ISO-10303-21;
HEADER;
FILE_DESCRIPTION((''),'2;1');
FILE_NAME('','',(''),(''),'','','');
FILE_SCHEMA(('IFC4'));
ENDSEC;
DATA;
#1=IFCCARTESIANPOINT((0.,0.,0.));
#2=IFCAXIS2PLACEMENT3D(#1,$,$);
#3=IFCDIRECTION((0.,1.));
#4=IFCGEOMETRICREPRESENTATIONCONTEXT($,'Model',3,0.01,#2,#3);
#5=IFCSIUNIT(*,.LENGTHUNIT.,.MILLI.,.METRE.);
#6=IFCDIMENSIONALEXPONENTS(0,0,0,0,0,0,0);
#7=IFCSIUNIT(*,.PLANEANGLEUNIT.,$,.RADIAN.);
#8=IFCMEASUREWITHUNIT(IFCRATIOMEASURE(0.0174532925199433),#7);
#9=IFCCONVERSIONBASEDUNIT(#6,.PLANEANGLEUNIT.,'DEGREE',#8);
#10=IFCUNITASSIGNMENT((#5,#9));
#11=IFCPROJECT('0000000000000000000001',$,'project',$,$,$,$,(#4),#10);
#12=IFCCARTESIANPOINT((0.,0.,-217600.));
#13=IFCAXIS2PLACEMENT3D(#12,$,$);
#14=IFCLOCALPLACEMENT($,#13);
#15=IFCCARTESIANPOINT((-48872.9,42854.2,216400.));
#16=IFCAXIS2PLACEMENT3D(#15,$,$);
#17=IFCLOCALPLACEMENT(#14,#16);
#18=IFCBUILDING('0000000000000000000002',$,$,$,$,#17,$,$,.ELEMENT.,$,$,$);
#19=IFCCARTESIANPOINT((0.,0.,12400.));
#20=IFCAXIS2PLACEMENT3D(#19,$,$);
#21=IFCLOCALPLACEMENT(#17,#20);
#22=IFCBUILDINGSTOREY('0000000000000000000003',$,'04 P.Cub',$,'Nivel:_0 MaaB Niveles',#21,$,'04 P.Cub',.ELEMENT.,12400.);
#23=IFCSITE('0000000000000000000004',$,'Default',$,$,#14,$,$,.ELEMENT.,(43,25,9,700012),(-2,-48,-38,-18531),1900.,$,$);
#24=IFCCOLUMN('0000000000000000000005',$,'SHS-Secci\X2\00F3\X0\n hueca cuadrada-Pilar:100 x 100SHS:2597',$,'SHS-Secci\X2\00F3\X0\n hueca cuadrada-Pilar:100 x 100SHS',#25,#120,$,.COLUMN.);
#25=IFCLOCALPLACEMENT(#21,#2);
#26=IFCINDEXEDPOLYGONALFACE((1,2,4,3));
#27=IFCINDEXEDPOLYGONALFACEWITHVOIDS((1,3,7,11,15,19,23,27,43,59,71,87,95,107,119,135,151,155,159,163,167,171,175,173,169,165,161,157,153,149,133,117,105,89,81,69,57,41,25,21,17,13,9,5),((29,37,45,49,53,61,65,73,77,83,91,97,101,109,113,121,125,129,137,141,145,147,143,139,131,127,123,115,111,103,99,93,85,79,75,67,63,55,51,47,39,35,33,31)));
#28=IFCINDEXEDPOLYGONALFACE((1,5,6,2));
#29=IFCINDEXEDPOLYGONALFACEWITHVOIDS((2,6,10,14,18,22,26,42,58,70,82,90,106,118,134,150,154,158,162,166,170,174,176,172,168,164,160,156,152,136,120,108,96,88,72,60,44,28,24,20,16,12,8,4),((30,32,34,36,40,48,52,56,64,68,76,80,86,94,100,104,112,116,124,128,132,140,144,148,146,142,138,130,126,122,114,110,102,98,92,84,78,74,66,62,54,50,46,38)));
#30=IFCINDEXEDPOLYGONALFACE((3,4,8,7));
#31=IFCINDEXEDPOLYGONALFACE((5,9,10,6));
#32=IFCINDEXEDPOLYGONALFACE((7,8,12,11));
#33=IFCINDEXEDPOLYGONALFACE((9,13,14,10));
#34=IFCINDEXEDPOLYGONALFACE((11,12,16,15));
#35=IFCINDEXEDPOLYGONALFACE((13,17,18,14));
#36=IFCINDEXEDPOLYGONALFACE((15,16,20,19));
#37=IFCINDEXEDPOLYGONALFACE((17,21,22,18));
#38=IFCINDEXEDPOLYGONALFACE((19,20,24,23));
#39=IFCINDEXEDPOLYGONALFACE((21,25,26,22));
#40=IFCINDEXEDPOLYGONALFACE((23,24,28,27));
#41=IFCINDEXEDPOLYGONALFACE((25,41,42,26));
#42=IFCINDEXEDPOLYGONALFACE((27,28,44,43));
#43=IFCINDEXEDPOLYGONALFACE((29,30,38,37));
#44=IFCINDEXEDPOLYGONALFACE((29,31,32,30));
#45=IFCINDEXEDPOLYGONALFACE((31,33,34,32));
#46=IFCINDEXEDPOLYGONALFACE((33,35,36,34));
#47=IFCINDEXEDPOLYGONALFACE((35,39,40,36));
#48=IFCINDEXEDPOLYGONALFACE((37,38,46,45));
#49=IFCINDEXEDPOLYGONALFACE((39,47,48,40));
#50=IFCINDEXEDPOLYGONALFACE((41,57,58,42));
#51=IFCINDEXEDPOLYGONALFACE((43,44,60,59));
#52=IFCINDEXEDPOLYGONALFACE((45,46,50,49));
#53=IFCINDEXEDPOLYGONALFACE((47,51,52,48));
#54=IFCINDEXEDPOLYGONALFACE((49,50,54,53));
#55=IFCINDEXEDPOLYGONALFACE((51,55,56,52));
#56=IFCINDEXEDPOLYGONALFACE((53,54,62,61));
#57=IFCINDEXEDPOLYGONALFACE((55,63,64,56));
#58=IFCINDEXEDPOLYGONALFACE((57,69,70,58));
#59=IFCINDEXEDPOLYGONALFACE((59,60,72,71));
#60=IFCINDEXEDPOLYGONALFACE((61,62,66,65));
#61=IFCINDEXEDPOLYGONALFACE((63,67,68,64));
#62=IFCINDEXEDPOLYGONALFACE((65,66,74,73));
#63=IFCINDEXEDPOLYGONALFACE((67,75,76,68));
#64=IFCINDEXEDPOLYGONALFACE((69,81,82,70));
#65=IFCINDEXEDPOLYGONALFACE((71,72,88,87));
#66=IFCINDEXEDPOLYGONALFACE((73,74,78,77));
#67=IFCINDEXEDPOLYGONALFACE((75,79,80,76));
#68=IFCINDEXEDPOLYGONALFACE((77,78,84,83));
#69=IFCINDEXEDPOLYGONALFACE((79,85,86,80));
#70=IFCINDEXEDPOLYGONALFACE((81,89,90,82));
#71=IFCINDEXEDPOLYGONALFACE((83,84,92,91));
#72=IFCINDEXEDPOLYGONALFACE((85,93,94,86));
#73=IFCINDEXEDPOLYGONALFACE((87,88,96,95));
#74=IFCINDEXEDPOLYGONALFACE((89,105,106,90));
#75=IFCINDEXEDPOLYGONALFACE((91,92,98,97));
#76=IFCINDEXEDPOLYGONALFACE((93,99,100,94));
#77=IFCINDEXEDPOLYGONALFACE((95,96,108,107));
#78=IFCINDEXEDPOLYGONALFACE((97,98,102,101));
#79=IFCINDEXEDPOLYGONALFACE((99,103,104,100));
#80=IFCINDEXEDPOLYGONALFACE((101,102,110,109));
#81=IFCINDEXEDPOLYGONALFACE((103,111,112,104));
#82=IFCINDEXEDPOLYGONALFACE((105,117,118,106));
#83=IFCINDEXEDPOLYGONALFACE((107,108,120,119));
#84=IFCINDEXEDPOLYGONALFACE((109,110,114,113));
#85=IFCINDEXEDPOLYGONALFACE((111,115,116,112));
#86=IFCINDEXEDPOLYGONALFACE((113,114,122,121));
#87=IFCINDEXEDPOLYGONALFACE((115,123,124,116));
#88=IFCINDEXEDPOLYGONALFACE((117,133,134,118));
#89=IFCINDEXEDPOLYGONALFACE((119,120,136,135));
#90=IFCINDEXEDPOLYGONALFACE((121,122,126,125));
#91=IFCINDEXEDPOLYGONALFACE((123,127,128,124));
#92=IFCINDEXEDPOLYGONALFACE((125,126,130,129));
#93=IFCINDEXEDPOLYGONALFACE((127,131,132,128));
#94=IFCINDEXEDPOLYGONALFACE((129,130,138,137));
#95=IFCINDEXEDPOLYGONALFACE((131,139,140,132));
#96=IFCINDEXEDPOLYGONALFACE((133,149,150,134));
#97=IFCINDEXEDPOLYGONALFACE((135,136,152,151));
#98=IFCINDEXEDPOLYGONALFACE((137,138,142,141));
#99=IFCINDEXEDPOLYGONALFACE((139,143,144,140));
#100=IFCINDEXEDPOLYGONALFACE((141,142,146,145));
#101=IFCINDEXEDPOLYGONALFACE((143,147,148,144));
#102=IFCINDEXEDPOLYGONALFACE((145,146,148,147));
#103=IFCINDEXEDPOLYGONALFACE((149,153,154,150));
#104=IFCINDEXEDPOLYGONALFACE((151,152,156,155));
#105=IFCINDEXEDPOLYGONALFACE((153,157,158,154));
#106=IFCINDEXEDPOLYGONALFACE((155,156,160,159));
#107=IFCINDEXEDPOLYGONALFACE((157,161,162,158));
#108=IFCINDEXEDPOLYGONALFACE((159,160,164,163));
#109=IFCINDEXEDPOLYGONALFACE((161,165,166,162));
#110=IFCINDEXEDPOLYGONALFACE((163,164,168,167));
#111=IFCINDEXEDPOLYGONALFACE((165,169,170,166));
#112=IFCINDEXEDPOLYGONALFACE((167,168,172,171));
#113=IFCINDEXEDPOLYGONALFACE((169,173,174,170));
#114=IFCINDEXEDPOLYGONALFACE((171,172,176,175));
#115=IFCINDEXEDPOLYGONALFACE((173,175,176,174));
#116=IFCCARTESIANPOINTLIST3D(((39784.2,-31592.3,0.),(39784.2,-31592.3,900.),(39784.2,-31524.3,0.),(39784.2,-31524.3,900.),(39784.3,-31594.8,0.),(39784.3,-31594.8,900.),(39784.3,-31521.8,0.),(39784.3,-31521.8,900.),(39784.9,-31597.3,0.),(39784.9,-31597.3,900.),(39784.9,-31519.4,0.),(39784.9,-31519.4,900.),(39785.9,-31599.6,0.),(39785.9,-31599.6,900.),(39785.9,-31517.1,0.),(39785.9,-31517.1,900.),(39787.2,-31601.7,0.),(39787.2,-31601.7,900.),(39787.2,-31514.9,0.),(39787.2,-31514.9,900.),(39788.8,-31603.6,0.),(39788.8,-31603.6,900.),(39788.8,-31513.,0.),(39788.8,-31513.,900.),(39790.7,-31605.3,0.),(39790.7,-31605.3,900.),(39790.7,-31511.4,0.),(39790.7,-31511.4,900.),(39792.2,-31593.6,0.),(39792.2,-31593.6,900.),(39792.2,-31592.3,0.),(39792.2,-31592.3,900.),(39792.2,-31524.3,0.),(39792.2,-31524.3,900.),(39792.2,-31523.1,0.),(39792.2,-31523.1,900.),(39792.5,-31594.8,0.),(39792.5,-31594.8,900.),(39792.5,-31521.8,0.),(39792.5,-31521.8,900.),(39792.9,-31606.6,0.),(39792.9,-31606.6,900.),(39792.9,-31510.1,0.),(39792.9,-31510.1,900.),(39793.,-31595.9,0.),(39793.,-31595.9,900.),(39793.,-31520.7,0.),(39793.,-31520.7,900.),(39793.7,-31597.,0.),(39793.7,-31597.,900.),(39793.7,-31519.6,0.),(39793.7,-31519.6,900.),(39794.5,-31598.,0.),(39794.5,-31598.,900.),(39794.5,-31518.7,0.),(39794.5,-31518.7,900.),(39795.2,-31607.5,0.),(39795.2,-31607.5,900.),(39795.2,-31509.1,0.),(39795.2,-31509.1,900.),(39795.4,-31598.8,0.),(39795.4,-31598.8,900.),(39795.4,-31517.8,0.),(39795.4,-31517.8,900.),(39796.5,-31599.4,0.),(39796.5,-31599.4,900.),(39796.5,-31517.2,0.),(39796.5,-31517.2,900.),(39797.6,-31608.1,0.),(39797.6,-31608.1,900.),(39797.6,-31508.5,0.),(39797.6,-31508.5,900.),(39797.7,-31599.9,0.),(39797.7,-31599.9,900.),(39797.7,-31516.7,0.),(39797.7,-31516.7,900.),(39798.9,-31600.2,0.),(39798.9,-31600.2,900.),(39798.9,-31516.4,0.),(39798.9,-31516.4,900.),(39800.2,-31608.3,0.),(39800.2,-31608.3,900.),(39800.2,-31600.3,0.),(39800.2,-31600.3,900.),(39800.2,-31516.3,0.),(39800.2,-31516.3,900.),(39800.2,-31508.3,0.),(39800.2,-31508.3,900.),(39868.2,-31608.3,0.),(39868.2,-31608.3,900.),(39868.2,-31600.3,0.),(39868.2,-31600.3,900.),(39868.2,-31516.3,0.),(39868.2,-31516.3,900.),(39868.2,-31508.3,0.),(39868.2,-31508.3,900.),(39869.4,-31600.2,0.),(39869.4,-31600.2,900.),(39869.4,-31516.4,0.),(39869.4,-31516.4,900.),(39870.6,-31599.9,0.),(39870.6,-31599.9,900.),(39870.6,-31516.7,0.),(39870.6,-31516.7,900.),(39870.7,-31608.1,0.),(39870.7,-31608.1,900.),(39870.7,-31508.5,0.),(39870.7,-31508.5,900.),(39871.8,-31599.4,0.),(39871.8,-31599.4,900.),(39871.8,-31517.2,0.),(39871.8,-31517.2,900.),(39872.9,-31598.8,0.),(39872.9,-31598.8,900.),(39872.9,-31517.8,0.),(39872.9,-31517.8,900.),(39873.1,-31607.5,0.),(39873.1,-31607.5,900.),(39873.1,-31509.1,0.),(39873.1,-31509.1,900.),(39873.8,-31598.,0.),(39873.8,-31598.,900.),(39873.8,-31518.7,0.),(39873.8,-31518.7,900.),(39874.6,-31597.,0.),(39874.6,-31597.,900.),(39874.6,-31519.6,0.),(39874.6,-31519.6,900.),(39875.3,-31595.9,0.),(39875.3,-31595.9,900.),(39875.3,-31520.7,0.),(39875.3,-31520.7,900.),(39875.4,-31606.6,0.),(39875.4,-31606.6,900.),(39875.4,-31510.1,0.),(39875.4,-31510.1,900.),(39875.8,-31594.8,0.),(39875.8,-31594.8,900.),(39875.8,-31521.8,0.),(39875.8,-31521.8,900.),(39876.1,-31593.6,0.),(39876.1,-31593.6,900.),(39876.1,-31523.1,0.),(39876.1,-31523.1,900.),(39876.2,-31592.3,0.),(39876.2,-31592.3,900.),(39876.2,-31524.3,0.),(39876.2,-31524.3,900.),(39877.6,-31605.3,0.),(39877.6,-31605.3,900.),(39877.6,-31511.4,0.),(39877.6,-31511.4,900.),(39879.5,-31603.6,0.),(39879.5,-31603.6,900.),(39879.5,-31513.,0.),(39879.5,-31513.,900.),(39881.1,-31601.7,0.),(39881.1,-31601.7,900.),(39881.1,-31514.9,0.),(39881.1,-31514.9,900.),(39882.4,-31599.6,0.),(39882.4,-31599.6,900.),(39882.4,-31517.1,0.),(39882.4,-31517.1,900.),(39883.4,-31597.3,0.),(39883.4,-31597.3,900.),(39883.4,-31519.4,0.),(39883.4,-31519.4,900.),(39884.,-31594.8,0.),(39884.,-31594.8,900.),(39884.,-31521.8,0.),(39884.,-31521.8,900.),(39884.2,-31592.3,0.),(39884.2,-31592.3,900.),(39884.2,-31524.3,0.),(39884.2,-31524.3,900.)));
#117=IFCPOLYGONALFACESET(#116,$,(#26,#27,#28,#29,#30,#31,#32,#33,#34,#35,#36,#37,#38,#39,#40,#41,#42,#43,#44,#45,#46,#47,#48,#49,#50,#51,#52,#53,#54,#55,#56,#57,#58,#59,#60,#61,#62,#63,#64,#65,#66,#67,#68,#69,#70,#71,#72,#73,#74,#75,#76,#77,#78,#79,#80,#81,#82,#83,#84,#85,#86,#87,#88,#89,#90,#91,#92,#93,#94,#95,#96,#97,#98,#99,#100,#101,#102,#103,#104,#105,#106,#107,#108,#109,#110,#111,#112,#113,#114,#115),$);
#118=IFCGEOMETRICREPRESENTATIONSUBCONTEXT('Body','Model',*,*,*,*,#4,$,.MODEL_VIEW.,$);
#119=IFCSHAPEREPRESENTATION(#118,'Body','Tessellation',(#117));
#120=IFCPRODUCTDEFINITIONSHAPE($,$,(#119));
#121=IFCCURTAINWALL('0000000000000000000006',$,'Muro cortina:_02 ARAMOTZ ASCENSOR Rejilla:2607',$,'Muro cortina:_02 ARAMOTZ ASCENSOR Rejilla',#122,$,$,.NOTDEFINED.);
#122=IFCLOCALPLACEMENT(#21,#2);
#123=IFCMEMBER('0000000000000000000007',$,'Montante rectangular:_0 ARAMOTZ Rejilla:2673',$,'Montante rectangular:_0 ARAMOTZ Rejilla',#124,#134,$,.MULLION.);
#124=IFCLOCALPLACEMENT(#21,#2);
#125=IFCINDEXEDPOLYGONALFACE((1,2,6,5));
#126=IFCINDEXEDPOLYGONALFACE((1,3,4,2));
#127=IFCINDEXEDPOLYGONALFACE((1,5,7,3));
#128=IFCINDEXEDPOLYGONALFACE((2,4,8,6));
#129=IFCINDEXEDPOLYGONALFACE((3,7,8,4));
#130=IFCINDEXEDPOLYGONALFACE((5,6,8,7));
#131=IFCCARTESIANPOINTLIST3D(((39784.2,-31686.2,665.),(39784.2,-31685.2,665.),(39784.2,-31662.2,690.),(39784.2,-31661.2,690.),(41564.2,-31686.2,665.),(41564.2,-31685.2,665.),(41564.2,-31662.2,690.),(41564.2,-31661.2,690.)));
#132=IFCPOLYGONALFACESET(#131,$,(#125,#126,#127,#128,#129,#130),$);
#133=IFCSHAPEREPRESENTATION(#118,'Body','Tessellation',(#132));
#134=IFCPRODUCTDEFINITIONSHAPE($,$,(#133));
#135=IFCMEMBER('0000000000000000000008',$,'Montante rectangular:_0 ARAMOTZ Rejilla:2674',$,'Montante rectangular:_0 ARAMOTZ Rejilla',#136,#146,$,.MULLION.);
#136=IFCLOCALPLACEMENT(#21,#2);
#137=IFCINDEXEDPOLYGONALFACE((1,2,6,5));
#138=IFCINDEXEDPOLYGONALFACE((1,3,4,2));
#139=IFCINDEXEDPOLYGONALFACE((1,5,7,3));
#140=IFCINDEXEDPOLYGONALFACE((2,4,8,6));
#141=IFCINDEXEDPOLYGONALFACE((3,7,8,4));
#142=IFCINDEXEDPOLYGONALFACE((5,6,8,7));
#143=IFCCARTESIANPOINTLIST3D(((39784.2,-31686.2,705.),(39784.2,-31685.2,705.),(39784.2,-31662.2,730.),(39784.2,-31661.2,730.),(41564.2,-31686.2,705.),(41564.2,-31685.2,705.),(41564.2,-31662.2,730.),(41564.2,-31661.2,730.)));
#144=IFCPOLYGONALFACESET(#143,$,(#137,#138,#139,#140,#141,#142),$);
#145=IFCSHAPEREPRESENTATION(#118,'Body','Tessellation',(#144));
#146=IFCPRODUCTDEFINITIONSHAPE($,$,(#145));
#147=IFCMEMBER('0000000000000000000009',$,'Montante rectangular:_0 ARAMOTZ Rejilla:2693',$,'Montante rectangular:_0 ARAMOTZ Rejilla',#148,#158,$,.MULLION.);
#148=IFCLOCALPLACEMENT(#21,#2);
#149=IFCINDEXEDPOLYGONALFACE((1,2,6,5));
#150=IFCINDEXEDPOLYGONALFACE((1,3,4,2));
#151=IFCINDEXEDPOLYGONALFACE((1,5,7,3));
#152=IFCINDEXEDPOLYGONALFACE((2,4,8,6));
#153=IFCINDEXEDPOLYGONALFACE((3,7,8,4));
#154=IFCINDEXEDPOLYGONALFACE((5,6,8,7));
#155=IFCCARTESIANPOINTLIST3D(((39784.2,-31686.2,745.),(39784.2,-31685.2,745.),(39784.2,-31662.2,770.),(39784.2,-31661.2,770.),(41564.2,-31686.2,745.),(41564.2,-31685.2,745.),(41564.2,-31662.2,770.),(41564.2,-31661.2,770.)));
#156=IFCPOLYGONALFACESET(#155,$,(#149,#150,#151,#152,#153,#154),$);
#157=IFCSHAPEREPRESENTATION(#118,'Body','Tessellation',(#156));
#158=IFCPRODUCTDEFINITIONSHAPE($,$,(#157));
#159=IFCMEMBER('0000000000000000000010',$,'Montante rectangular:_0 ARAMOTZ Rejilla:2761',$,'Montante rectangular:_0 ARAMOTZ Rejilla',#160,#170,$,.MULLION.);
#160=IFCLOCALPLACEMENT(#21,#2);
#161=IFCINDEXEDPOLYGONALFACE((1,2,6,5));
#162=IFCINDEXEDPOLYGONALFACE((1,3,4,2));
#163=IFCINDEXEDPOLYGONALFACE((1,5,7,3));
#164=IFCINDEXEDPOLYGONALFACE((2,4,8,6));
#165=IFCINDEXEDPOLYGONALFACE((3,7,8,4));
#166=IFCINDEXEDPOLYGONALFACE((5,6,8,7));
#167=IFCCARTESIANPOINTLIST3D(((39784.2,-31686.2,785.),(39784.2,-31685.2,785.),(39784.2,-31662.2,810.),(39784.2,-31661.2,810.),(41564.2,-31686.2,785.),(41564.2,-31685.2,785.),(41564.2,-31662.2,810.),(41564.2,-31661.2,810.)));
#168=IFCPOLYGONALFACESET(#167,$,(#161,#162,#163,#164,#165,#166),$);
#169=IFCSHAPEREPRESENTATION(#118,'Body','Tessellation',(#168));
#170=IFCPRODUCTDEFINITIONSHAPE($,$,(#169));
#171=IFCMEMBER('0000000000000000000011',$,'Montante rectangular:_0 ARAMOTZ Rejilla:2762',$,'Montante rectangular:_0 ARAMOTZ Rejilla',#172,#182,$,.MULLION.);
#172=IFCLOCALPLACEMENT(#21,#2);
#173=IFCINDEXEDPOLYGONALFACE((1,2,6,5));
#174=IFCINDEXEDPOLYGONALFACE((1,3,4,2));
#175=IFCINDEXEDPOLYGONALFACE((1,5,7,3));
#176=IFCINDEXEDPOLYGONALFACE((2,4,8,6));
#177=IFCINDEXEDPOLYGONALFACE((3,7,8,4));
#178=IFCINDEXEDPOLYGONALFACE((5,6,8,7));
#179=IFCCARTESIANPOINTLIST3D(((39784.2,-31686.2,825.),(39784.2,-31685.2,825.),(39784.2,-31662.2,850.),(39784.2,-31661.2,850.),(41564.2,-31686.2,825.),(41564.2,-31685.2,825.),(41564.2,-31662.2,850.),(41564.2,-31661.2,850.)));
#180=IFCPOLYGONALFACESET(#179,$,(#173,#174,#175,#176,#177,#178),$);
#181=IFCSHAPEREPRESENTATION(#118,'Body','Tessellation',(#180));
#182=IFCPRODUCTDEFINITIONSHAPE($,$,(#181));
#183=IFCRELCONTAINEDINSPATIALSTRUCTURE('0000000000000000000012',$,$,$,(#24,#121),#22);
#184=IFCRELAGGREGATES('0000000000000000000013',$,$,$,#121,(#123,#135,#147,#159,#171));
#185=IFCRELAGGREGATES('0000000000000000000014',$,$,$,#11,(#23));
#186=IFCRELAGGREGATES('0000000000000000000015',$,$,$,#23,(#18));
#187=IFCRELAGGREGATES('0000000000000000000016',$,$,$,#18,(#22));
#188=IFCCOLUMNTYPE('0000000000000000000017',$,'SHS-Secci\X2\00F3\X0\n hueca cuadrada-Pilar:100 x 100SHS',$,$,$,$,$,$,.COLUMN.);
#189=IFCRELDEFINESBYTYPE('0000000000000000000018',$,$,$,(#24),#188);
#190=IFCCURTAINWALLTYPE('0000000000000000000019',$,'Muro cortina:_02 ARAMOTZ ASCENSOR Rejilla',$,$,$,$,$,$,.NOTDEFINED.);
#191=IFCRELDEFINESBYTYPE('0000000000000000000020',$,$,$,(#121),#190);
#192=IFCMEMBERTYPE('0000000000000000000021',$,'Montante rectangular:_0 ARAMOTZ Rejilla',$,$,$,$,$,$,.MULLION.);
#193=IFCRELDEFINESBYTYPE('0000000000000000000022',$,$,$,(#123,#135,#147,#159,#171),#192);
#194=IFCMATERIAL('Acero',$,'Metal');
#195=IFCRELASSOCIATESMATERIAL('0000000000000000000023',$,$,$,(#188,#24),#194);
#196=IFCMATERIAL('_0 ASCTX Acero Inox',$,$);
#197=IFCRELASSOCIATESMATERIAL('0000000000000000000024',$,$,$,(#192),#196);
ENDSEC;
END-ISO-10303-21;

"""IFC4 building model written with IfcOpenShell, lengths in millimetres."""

from ifc_helpers import new_model, entity, si_unit, converted_unit, direction, frame, origin, place, context, subcontext, project, spatial, indexed_curve, outline, extrude, source, transform, mapped, material, type_object, type_shapes, element, aggregate, save


model = new_model("IFC4")

# Units and contexts
model_context = context("Model", 3, precision=0.01, world=origin(), true_north=direction((0.0, 1.0)))
body_context = subcontext(model_context, "Body", "Model", "MODEL_VIEW")
ifc_project = project(units=[si_unit("LENGTHUNIT", "METRE", prefix="MILLI"), converted_unit("PLANEANGLEUNIT", "DEGREE", entity("IfcRatioMeasure", 0.0174532925199433), si_unit("PLANEANGLEUNIT", "RADIAN"), dimensions=[0, 0, 0, 0, 0, 0, 0])], contexts=[model_context])

# Site, building, storey
site_placement = place(None, frame((0.0, 0.0, -217600.0)))
site = spatial("IfcSite", under=ifc_project, at=site_placement, Name="Default", CompositionType="ELEMENT", RefLatitude=(43, 25, 9, 700012), RefLongitude=(-2, -48, -38, -18531), RefElevation=1900.0)
building_placement = place(site_placement, frame((-48872.9, 42854.2, 216400.0)))
building = spatial("IfcBuilding", under=site, at=building_placement, CompositionType="ELEMENT")
storey_placement = place(building_placement, frame((0.0, 0.0, 12400.0)))
storey = spatial("IfcBuildingStorey", under=building, at=storey_placement, Name="04 P.Cub", ObjectType="Nivel:_0 MaaB Niveles", LongName="04 P.Cub", CompositionType="ELEMENT", Elevation=12400.0)

# Column
ifc_material_1 = material(Name="Acero", Category="Metal")
column_type_1 = type_object("IfcColumnType", Name="SHS-Sección hueca cuadrada-Pilar:100 x 100SHS", PredefinedType="COLUMN", material=ifc_material_1)
shared_shape_1 = source(origin(), body_context, "Body", "SweptSolid", [
    extrude(outline(indexed_curve([(-34.0, -50.0), (34.0, -50.0), (36.5, -49.8), (38.9, -49.2), (41.3, -48.3), (43.4, -46.9), (45.3, -45.3), (46.9, -43.4), (48.3, -41.3), (49.2, -38.9), (49.8, -36.5), (50.0, -34.0), (50.0, 34.0), (49.8, 36.5), (49.2, 38.9), (48.3, 41.3), (46.9, 43.4), (45.3, 45.3), (43.4, 46.9), (41.3, 48.3), (38.9, 49.2), (36.5, 49.8), (34.0, 50.0), (-34.0, 50.0), (-36.5, 49.8), (-38.9, 49.2), (-41.3, 48.3), (-43.4, 46.9), (-45.3, 45.3), (-46.9, 43.4), (-48.3, 41.3), (-49.2, 38.9), (-49.8, 36.5), (-50.0, 34.0), (-50.0, -34.0), (-49.8, -36.5), (-49.2, -38.9), (-48.3, -41.3), (-46.9, -43.4), (-45.3, -45.3), (-43.4, -46.9), (-41.3, -48.3), (-38.9, -49.2), (-36.5, -49.8), (-34.0, -50.0)], self_intersect=False), holes=[indexed_curve([(-34.0, -42.0), (-35.3, -41.9), (-36.5, -41.6), (-37.6, -41.1), (-38.7, -40.5), (-39.7, -39.7), (-40.5, -38.7), (-41.1, -37.6), (-41.6, -36.5), (-41.9, -35.3), (-42.0, -34.0), (-42.0, 34.0), (-41.9, 35.3), (-41.6, 36.5), (-41.1, 37.6), (-40.5, 38.7), (-39.7, 39.7), (-38.7, 40.5), (-37.6, 41.1), (-36.5, 41.6), (-35.3, 41.9), (-34.0, 42.0), (34.0, 42.0), (35.3, 41.9), (36.5, 41.6), (37.6, 41.1), (38.7, 40.5), (39.7, 39.7), (40.5, 38.7), (41.1, 37.6), (41.6, 36.5), (41.9, 35.3), (42.0, 34.0), (42.0, -34.0), (41.9, -35.3), (41.6, -36.5), (41.1, -37.6), (40.5, -38.7), (39.7, -39.7), (38.7, -40.5), (37.6, -41.1), (36.5, -41.6), (35.3, -41.9), (34.0, -42.0), (-34.0, -42.0)], self_intersect=False)]), frame((0.0, 0.0, 12400.0), z_axis=(0.0, 0.0, 1.0), x_axis=(-1.0, 0.0, 0.0)), (0.0, 0.0, 1.0), 900.0),
])
type_shapes(column_type_1, [shared_shape_1])
column_1_placement = place(storey_placement, frame((39834.2, -31558.3, -12400.0), z_axis=(0.0, 0.0, 1.0), x_axis=(0.0, -1.0, 0.0)))
element("IfcColumn", 1, at=column_1_placement, inside=storey, type_object=column_type_1, material=ifc_material_1, Name="SHS-Sección hueca cuadrada-Pilar:100 x 100SHS:2597", ObjectType="SHS-Sección hueca cuadrada-Pilar:100 x 100SHS", PredefinedType="COLUMN", context=body_context, shape_type="MappedRepresentation", body=[
    mapped(shared_shape_1, transform((0.0, 0.0, 0.0), scale=1.0)),
])

# Curtain wall, members
curtain_wall_type = type_object("IfcCurtainWallType", Name="Muro cortina:_02 ARAMOTZ ASCENSOR Rejilla", PredefinedType="NOTDEFINED")
curtain_wall_placement = place(storey_placement, frame((0.0, 0.0, -12400.0)))
curtain_wall = element("IfcCurtainWall", 2, at=curtain_wall_placement, inside=storey, type_object=curtain_wall_type, Name="Muro cortina:_02 ARAMOTZ ASCENSOR Rejilla:2607", ObjectType="Muro cortina:_02 ARAMOTZ ASCENSOR Rejilla", PredefinedType="NOTDEFINED")
ifc_material_2 = material(Name="_0 ASCTX Acero Inox")
member_type = type_object("IfcMemberType", Name="Montante rectangular:_0 ARAMOTZ Rejilla", PredefinedType="MULLION", material=ifc_material_2)
shared_shape_2 = source(origin(), body_context, "Body", "SweptSolid", [
    extrude(outline(indexed_curve([(11.5, -12.5), (12.5, -12.5), (-11.5, 12.5), (-12.5, 12.5), (11.5, -12.5)], self_intersect=False)), frame((-12.5, -22.5, -1780.0), z_axis=(0.0, 0.0, 1.0), x_axis=(0.0, -1.0, 0.0)), (0.0, 0.0, 1.0), 1780.0),
])
type_shapes(member_type, [shared_shape_2])
member_1_placement = place(curtain_wall_placement, frame((39784.2, -31651.2, 13090.0), z_axis=(-1.0, 0.0, 0.0), x_axis=(0.0, 0.0, 1.0)))
member_1 = element("IfcMember", 3, at=member_1_placement, type_object=member_type, Name="Montante rectangular:_0 ARAMOTZ Rejilla:2673", ObjectType="Montante rectangular:_0 ARAMOTZ Rejilla", PredefinedType="MULLION", context=body_context, shape_type="MappedRepresentation", body=[
    mapped(shared_shape_2, transform((0.0, 0.0, 0.0), scale=1.0)),
])
member_2_placement = place(curtain_wall_placement, frame((39784.2, -31651.2, 13130.0), z_axis=(-1.0, 0.0, 0.0), x_axis=(0.0, 0.0, 1.0)))
member_2 = element("IfcMember", 4, at=member_2_placement, type_object=member_type, Name="Montante rectangular:_0 ARAMOTZ Rejilla:2674", ObjectType="Montante rectangular:_0 ARAMOTZ Rejilla", PredefinedType="MULLION", context=body_context, shape_type="MappedRepresentation", body=[
    mapped(shared_shape_2, transform((0.0, 0.0, 0.0), scale=1.0)),
])
member_3_placement = place(curtain_wall_placement, frame((39784.2, -31651.2, 13170.0), z_axis=(-1.0, 0.0, 0.0), x_axis=(0.0, 0.0, 1.0)))
member_3 = element("IfcMember", 5, at=member_3_placement, type_object=member_type, Name="Montante rectangular:_0 ARAMOTZ Rejilla:2693", ObjectType="Montante rectangular:_0 ARAMOTZ Rejilla", PredefinedType="MULLION", context=body_context, shape_type="MappedRepresentation", body=[
    mapped(shared_shape_2, transform((0.0, 0.0, 0.0), scale=1.0)),
])
member_4_placement = place(curtain_wall_placement, frame((39784.2, -31651.2, 13210.0), z_axis=(-1.0, 0.0, 0.0), x_axis=(0.0, 0.0, 1.0)))
member_4 = element("IfcMember", 6, at=member_4_placement, type_object=member_type, Name="Montante rectangular:_0 ARAMOTZ Rejilla:2761", ObjectType="Montante rectangular:_0 ARAMOTZ Rejilla", PredefinedType="MULLION", context=body_context, shape_type="MappedRepresentation", body=[
    mapped(shared_shape_2, transform((0.0, 0.0, 0.0), scale=1.0)),
])
member_5_placement = place(curtain_wall_placement, frame((39784.2, -31651.2, 13250.0), z_axis=(-1.0, 0.0, 0.0), x_axis=(0.0, 0.0, 1.0)))
member_5 = element("IfcMember", 7, at=member_5_placement, type_object=member_type, Name="Montante rectangular:_0 ARAMOTZ Rejilla:2762", ObjectType="Montante rectangular:_0 ARAMOTZ Rejilla", PredefinedType="MULLION", context=body_context, shape_type="MappedRepresentation", body=[
    mapped(shared_shape_2, transform((0.0, 0.0, 0.0), scale=1.0)),
])

aggregate(curtain_wall, [member_1, member_2, member_3, member_4, member_5])

save(model, "model.ifc")
